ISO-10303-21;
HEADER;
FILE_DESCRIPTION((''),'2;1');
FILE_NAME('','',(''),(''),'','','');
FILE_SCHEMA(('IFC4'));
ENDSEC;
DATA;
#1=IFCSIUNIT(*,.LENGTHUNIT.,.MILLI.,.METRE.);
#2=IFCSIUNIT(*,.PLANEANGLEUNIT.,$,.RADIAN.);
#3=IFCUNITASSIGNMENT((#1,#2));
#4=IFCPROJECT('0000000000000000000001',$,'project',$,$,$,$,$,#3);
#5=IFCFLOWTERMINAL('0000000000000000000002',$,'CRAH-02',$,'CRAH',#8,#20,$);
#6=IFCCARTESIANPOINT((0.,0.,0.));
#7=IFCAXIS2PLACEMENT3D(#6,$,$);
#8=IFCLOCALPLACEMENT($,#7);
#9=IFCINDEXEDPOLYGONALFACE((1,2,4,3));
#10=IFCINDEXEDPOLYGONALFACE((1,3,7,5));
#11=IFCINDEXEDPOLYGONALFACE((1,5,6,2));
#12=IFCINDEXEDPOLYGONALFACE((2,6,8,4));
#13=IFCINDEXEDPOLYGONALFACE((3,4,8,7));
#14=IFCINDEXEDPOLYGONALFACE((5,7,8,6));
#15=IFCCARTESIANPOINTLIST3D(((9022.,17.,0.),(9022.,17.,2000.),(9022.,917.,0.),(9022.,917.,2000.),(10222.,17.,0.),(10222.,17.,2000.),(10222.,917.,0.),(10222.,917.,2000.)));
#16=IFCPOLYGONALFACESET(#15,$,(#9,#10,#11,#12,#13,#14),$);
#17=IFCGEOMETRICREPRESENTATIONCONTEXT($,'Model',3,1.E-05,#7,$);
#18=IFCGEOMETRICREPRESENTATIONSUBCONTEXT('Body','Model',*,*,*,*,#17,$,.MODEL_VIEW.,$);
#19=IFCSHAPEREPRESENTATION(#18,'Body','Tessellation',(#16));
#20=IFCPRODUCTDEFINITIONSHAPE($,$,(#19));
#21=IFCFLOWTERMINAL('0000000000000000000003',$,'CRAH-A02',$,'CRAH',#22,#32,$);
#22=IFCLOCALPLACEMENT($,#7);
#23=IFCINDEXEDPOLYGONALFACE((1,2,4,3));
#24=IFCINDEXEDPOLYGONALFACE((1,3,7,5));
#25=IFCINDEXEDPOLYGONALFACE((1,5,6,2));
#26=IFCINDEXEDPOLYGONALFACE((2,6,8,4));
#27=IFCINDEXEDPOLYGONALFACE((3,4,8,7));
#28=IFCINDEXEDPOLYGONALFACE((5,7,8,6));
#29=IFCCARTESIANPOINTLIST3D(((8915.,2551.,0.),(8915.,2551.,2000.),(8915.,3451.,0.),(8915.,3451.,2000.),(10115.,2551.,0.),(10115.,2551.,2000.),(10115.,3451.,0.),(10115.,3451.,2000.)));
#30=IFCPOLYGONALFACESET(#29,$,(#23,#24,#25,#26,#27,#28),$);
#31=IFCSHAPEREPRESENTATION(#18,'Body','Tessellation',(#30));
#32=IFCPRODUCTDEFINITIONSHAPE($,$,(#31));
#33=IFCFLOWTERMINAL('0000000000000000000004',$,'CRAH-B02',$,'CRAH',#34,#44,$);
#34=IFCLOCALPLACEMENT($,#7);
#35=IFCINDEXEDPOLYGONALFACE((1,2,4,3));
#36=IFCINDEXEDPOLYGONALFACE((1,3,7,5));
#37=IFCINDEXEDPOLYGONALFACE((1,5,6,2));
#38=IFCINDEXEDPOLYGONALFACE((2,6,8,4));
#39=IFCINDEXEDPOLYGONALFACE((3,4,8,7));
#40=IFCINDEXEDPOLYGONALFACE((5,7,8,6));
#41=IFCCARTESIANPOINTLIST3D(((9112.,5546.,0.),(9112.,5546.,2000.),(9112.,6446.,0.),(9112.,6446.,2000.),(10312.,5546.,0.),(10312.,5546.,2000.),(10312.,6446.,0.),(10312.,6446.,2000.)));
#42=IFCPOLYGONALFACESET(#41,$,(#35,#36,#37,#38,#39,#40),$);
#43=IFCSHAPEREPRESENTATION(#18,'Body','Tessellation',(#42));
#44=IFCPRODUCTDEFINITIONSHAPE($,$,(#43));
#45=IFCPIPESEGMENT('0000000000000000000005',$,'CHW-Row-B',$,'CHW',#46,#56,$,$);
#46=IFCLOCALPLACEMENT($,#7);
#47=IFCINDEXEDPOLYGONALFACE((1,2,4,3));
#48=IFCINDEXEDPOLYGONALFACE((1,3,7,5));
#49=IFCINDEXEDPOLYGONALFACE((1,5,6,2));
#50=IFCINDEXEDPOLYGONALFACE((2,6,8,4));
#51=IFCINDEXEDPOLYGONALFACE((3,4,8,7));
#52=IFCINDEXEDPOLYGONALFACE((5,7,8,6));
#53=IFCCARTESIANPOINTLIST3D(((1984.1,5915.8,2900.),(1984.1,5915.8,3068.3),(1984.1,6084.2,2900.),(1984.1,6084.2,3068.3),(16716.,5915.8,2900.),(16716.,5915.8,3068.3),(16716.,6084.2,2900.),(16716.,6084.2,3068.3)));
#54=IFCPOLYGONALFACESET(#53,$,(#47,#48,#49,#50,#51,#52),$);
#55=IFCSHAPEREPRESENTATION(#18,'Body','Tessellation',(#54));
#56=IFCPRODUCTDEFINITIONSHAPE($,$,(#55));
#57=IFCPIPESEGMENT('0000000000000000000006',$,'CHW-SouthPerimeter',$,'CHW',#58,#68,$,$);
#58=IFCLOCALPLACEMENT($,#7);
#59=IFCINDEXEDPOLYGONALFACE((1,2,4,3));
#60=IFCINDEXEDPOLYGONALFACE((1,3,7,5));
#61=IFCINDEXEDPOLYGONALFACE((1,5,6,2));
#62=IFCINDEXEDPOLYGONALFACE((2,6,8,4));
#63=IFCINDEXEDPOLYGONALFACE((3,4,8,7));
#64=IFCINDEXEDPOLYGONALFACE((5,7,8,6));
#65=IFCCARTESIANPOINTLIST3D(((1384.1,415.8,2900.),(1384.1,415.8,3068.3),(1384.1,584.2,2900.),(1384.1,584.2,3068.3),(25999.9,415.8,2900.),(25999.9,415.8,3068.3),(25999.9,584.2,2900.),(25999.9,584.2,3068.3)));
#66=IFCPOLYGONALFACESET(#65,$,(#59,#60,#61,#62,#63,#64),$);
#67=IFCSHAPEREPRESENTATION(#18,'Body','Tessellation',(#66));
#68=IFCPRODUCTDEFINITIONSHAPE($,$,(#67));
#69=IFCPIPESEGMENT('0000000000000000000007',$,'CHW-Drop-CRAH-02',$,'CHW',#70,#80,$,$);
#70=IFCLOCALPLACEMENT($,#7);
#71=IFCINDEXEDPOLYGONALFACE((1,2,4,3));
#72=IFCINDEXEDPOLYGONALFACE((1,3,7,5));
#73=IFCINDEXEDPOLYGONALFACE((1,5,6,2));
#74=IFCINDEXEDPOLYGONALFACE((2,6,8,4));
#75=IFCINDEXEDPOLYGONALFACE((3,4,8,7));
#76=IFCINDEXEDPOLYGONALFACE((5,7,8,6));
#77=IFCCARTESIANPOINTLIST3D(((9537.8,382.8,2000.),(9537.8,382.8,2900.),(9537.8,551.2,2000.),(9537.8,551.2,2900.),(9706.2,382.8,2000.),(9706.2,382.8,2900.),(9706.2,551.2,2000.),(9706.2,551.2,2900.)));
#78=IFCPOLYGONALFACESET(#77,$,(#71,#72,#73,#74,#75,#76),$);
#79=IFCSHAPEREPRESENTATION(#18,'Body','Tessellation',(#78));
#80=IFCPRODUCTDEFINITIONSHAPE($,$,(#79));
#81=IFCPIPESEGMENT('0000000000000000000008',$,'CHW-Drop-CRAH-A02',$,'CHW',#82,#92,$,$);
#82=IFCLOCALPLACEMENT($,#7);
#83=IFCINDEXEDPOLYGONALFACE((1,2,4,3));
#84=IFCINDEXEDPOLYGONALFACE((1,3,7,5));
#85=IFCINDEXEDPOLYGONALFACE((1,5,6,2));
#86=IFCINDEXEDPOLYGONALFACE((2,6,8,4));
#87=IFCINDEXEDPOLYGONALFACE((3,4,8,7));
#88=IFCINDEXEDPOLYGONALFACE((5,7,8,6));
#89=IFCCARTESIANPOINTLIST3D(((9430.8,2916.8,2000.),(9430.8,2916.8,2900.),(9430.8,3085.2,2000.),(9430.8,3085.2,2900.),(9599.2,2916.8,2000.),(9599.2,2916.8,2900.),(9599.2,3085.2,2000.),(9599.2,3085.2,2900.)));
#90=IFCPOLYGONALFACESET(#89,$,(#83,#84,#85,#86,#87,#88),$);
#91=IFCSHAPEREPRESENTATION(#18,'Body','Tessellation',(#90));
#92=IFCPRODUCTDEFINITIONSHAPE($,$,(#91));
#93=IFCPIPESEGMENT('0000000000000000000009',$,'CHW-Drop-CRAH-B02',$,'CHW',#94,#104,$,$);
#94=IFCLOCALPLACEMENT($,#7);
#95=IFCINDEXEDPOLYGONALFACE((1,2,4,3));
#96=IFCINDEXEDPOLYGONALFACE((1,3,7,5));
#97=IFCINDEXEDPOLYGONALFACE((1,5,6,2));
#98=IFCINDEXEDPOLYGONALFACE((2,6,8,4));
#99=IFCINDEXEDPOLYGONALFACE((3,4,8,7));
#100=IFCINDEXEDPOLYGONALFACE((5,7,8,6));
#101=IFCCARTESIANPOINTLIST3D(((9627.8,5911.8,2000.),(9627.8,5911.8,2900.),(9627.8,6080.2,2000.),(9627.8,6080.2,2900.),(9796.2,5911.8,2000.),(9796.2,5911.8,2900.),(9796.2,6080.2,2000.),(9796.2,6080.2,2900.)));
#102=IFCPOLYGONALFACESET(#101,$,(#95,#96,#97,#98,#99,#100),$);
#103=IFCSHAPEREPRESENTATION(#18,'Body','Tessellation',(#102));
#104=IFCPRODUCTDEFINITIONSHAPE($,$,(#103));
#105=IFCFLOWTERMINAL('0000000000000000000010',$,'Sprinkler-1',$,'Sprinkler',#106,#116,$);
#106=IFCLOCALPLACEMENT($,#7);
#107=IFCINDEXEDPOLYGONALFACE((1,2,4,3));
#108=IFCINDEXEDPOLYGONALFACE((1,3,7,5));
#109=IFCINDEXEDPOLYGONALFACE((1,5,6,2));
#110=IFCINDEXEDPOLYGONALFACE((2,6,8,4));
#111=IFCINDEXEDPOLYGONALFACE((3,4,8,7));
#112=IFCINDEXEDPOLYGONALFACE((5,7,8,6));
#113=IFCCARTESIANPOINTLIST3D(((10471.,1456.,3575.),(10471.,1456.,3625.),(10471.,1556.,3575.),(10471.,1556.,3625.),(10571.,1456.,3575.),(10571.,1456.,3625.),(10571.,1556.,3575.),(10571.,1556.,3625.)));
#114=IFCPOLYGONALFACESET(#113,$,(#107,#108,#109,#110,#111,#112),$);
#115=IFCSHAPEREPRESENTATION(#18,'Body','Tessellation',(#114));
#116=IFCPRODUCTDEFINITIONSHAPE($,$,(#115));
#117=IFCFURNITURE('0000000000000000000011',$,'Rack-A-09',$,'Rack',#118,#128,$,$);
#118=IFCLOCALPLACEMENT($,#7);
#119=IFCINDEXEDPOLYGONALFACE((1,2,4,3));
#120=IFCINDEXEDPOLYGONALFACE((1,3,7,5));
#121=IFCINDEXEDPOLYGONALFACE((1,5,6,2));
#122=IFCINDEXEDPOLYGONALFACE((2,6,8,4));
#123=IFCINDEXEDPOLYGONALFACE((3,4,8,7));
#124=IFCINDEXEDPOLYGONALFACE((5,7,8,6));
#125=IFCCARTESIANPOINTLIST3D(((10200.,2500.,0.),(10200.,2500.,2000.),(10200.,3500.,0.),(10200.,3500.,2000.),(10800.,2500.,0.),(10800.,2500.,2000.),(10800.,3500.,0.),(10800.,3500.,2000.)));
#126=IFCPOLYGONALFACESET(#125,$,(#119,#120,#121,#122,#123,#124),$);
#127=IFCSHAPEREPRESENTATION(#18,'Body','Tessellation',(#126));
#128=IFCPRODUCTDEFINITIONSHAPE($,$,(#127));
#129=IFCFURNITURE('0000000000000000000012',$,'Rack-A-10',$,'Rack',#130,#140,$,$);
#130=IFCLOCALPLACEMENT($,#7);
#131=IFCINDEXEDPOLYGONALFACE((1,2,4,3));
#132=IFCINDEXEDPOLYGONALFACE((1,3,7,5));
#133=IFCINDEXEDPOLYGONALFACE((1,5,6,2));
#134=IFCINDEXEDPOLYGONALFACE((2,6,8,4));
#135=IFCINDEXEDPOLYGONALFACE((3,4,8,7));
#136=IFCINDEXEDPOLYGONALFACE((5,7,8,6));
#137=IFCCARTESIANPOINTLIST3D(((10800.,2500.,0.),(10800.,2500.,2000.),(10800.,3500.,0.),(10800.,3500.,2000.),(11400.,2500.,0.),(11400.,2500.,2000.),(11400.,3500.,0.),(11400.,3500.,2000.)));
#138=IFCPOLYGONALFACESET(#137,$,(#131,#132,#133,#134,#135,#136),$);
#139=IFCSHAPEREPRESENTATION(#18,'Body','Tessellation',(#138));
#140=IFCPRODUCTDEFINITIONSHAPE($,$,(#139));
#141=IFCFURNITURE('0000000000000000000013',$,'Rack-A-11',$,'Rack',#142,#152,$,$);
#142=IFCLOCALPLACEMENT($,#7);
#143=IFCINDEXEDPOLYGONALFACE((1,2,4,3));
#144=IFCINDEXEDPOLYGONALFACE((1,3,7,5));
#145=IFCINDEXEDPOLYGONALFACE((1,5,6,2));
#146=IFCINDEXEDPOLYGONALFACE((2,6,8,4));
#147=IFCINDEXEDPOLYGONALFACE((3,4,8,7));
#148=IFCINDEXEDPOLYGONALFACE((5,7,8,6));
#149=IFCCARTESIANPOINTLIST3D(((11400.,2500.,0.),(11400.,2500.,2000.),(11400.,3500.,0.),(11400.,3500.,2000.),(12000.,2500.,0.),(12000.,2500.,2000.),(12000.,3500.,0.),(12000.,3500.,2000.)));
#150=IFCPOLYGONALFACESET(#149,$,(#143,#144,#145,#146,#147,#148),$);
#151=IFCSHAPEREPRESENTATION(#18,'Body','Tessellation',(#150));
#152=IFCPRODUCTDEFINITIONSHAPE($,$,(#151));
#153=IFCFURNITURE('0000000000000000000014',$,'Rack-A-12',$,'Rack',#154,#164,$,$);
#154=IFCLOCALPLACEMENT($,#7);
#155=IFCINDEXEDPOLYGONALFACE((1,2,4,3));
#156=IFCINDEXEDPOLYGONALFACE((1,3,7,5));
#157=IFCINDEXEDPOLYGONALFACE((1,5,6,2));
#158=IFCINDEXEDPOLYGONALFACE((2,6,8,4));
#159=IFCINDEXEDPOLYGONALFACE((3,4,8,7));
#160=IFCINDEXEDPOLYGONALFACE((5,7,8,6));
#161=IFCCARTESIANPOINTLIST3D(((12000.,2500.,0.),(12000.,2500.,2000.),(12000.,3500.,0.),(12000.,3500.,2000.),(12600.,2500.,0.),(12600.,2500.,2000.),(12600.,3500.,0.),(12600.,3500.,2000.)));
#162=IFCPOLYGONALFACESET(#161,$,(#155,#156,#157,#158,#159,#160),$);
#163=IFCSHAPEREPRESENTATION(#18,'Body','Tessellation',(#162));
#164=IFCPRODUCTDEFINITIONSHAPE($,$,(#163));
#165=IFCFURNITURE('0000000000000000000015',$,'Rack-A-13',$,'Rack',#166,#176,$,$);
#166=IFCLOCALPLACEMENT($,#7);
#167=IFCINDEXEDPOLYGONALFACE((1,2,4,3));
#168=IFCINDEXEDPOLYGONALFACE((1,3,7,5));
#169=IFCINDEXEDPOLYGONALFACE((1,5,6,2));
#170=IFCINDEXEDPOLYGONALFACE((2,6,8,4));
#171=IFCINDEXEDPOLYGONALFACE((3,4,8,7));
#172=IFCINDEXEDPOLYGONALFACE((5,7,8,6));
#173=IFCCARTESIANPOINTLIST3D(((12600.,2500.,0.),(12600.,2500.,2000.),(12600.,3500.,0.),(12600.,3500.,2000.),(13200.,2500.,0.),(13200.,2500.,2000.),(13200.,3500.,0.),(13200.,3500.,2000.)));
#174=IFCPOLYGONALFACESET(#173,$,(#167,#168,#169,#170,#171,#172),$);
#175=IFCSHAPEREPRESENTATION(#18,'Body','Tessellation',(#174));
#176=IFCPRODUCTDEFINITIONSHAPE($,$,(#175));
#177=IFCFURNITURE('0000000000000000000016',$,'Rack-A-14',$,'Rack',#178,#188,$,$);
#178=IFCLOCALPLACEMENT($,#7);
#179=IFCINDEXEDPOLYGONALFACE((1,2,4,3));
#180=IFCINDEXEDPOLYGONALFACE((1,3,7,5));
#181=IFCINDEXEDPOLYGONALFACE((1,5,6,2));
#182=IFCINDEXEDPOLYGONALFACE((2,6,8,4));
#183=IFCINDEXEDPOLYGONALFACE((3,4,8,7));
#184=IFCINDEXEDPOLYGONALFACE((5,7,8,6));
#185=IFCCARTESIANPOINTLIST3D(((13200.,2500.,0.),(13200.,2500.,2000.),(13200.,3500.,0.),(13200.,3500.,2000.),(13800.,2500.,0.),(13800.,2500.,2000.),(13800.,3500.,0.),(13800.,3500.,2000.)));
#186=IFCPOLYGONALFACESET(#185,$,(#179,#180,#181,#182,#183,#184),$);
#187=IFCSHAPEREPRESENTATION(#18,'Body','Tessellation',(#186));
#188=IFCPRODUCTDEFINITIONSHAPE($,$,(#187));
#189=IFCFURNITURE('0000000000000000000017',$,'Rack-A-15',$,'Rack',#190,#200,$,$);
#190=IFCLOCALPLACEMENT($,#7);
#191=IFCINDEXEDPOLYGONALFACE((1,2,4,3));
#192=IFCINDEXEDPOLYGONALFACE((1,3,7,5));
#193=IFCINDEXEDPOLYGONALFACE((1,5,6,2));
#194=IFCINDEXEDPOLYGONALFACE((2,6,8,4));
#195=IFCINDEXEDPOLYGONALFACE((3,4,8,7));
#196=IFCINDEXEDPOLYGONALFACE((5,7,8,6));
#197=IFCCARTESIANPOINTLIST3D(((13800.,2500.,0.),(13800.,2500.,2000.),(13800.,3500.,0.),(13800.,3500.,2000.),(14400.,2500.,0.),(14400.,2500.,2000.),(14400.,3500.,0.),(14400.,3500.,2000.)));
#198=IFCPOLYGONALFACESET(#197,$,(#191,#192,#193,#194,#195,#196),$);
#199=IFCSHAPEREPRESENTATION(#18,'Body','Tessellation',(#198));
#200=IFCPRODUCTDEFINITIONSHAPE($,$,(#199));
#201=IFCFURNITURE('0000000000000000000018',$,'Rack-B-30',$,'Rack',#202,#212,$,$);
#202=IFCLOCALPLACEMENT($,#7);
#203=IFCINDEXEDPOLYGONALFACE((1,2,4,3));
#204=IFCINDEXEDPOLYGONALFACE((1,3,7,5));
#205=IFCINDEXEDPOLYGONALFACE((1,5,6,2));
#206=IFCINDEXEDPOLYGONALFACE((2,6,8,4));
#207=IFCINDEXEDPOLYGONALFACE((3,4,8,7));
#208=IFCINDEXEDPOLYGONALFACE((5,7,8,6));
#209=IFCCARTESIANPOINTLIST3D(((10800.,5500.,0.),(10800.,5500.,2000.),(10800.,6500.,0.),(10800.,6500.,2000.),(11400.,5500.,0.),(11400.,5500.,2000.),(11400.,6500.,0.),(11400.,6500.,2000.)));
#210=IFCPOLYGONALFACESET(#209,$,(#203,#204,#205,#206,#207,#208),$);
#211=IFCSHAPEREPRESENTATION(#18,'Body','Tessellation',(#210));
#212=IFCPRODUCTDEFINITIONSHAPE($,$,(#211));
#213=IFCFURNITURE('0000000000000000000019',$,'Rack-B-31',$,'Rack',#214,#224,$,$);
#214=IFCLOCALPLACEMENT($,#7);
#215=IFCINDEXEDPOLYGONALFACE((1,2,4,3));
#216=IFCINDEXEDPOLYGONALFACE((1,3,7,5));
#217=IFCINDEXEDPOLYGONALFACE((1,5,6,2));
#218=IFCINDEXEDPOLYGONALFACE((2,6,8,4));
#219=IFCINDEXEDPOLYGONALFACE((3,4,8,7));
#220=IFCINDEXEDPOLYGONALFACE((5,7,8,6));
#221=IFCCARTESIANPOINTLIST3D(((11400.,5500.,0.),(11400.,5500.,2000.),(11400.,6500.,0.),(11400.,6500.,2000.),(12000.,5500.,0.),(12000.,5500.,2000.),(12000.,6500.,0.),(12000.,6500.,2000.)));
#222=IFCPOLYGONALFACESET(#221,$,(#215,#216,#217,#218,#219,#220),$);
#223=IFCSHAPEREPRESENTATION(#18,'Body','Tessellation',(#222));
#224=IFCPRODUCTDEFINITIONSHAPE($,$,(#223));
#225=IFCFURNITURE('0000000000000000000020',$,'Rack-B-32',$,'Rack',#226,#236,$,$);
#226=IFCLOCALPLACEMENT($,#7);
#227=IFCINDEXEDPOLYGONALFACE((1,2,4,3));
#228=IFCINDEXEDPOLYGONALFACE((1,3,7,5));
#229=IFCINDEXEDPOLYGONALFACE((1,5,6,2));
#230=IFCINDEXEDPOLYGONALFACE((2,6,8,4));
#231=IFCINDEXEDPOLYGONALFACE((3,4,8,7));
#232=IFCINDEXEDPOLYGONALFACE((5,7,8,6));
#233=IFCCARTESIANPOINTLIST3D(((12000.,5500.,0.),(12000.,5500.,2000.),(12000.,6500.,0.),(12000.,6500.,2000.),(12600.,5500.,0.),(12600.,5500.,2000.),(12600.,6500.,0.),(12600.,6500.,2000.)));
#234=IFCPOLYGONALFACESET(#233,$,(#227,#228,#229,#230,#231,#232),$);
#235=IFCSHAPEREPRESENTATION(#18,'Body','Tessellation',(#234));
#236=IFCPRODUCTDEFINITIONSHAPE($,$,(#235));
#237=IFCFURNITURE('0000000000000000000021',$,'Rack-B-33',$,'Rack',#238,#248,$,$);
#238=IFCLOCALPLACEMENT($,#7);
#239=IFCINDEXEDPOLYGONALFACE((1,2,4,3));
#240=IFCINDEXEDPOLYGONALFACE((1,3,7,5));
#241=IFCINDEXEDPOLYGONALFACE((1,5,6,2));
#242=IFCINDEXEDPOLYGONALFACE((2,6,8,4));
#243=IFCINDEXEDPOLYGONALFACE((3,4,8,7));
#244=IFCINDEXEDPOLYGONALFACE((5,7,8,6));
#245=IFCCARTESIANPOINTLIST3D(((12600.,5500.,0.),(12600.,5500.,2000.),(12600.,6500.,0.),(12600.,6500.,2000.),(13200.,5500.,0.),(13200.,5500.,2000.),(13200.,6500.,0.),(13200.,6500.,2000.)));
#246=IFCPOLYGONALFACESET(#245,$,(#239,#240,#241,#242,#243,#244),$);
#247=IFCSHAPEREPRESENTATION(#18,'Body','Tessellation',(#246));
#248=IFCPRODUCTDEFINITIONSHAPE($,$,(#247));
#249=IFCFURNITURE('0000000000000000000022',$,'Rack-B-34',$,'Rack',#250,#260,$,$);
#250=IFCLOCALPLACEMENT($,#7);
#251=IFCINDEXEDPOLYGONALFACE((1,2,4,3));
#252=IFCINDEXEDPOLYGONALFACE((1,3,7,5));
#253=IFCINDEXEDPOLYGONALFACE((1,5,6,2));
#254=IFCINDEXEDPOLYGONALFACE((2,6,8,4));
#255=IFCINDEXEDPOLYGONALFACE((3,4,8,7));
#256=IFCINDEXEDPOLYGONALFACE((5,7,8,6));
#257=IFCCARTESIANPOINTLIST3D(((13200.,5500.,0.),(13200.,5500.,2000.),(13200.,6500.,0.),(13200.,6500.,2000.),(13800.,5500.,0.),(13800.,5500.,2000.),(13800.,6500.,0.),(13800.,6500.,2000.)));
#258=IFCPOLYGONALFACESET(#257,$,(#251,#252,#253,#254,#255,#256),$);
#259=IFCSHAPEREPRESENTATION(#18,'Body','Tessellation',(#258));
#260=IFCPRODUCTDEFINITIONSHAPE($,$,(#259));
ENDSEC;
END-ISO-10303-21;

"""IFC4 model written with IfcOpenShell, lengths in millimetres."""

from ifc_helpers import new_model, si_unit, frame, origin, place, context, subcontext, project, rectangle, extrude, element, save


model = new_model("IFC4")

# Units and contexts
model_context = context("Model", 3, precision=1e-05, world=origin())
body_context = subcontext(model_context, "Body", "Model", "MODEL_VIEW")
ifc_project = project(units=[si_unit("LENGTHUNIT", "METRE", prefix="MILLI"), si_unit("PLANEANGLEUNIT", "RADIAN")])

# Flow terminals
for number, where, name in (
    (1, (9622.0, 467.0, 0.0), "CRAH-02"),
    (2, (9515.0, 3001.0, 0.0), "CRAH-A02"),
    (3, (9712.0, 5996.0, 0.0), "CRAH-B02"),
):
    element("IfcFlowTerminal", number, at=place(None, frame(where)), Name=name, ObjectType="CRAH", context=body_context, shape_type="SweptSolid", body=[
        extrude(rectangle(XDim=1200.0, YDim=900.0), None, (0.0, 0.0, 1.0), 2000.0),
    ])

# Pipe segments
pipe_segment_1_placement = place(None, frame((9350.1, 6000.0, 2900.0)))
element("IfcPipeSegment", 4, at=pipe_segment_1_placement, Name="CHW-Row-B", ObjectType="CHW", context=body_context, shape_type="SweptSolid", body=[
    extrude(rectangle(XDim=14731.9, YDim=168.3), None, (0.0, 0.0, 1.0), 168.3),
])
pipe_segment_2_placement = place(None, frame((13692.0, 500.0, 2900.0)))
element("IfcPipeSegment", 5, at=pipe_segment_2_placement, Name="CHW-SouthPerimeter", ObjectType="CHW", context=body_context, shape_type="SweptSolid", body=[
    extrude(rectangle(XDim=24615.8, YDim=168.3), None, (0.0, 0.0, 1.0), 168.3),
])
for number, where, name in (
    (6, (9622.0, 467.0, 2000.0), "CHW-Drop-CRAH-02"),
    (7, (9515.0, 3001.0, 2000.0), "CHW-Drop-CRAH-A02"),
    (8, (9712.0, 5996.0, 2000.0), "CHW-Drop-CRAH-B02"),
):
    element("IfcPipeSegment", number, at=place(None, frame(where)), Name=name, ObjectType="CHW", context=body_context, shape_type="SweptSolid", body=[
        extrude(rectangle(XDim=168.3, YDim=168.3), None, (0.0, 0.0, 1.0), 900.0),
    ])

# Flow terminal
flow_terminal_placement = place(None, frame((10521.0, 1506.0, 3575.0)))
element("IfcFlowTerminal", 9, at=flow_terminal_placement, Name="Sprinkler-1", ObjectType="Sprinkler", context=body_context, shape_type="SweptSolid", body=[
    extrude(rectangle(XDim=100.0, YDim=100.0), None, (0.0, 0.0, 1.0), 50.0),
])

# Furniture
for number, where, name in (
    (10, (10500.0, 3000.0, 0.0), "Rack-A-09"),
    (11, (11100.0, 3000.0, 0.0), "Rack-A-10"),
    (12, (11700.0, 3000.0, 0.0), "Rack-A-11"),
    (13, (12300.0, 3000.0, 0.0), "Rack-A-12"),
    (14, (12900.0, 3000.0, 0.0), "Rack-A-13"),
    (15, (13500.0, 3000.0, 0.0), "Rack-A-14"),
    (16, (14100.0, 3000.0, 0.0), "Rack-A-15"),
    (17, (11100.0, 6000.0, 0.0), "Rack-B-30"),
    (18, (11700.0, 6000.0, 0.0), "Rack-B-31"),
    (19, (12300.0, 6000.0, 0.0), "Rack-B-32"),
    (20, (12900.0, 6000.0, 0.0), "Rack-B-33"),
    (21, (13500.0, 6000.0, 0.0), "Rack-B-34"),
):
    element("IfcFurniture", number, at=place(None, frame(where)), Name=name, ObjectType="Rack", context=body_context, shape_type="SweptSolid", body=[
        extrude(rectangle(XDim=600.0, YDim=1000.0), None, (0.0, 0.0, 1.0), 2000.0),
    ])

save(model, "model.ifc")
